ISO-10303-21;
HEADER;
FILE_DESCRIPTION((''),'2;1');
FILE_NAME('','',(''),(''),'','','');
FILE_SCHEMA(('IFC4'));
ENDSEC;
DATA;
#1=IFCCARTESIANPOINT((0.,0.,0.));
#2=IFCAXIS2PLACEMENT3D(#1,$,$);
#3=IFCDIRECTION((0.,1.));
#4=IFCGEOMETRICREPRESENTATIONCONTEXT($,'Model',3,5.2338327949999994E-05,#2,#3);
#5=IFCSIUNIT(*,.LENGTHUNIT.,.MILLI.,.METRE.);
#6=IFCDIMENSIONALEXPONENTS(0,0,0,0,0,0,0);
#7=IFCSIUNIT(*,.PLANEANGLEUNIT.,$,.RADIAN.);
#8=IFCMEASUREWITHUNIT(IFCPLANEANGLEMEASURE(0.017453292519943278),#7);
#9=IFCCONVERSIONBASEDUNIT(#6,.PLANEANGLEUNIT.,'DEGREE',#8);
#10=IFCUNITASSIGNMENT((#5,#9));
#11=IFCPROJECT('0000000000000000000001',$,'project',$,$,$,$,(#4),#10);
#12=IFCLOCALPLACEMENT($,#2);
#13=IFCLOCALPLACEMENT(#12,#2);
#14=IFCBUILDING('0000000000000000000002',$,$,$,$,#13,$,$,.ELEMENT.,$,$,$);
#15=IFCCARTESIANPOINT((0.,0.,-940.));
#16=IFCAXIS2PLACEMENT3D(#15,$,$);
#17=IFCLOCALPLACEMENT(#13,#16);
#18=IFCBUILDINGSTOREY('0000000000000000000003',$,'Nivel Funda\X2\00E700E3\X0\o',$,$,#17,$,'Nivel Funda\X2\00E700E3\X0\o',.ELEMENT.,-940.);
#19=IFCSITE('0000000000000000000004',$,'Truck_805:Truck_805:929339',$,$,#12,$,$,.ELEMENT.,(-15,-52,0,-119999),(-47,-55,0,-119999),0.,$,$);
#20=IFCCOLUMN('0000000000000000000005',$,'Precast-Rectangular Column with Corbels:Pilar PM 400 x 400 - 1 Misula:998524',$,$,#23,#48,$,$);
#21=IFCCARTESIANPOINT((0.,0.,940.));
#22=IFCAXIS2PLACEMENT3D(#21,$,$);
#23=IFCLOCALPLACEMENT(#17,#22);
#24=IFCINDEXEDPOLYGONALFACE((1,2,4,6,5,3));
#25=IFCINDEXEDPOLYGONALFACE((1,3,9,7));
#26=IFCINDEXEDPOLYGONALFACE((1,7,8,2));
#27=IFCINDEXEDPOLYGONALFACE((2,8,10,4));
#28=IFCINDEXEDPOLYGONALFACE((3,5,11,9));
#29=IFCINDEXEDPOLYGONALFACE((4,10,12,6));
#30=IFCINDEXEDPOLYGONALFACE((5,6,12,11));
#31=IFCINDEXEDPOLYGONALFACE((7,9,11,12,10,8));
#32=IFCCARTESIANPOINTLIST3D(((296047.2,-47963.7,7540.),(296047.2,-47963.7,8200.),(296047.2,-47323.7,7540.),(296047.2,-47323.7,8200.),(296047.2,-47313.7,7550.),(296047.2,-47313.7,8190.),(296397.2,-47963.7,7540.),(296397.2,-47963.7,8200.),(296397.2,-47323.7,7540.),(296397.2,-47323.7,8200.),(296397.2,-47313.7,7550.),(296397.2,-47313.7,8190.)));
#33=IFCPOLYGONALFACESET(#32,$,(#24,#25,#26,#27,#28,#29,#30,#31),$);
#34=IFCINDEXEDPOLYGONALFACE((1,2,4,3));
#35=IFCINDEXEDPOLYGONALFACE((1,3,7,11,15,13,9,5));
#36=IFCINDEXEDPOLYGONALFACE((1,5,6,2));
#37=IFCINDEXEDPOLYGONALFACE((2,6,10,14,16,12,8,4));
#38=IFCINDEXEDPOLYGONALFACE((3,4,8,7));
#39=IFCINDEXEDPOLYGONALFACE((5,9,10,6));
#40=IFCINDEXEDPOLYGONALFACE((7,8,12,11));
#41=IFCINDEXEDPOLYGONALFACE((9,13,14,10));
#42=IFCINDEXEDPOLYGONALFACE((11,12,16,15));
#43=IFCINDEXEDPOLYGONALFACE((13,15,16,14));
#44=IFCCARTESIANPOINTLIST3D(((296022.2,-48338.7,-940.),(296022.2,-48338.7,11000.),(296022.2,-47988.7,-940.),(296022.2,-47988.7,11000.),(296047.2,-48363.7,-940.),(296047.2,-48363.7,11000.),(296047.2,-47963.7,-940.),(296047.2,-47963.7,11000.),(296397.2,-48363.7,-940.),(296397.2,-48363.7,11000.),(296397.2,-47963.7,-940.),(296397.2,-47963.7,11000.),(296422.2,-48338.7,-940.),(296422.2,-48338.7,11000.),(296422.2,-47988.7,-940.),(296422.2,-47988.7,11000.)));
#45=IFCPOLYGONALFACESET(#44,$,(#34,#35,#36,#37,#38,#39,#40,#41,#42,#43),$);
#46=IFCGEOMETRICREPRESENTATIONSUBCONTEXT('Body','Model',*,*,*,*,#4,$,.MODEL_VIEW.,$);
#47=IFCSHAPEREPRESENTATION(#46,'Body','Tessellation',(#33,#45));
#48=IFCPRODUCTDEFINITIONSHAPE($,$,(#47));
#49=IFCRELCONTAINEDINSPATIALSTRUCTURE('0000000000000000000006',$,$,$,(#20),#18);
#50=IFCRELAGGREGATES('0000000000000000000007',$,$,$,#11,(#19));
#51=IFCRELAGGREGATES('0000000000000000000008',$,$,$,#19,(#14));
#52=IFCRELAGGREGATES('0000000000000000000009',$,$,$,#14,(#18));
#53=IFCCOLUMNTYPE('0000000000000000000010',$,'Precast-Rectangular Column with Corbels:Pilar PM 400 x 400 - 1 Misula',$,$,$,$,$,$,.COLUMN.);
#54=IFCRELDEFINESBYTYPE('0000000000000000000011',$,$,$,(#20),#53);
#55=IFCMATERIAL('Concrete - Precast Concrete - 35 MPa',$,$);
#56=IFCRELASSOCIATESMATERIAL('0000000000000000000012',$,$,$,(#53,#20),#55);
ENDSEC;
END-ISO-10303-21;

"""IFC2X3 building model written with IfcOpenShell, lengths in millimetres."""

from ifc_helpers import new_model, entity, si_unit, converted_unit, direction, frame, origin, place, context, subcontext, project, spatial, polyline, outline, extrude, source, transform, mapped, material, type_object, type_shapes, element, save


model = new_model("IFC2X3")

# Units and contexts
model_context = context("Model", 3, precision=5.2338327949999994e-05, world=origin(), true_north=direction((0.0, 1.0)))
body_context = subcontext(model_context, "Body", "Model", "MODEL_VIEW")
ifc_project = project(units=[si_unit("LENGTHUNIT", "METRE", prefix="MILLI"), converted_unit("PLANEANGLEUNIT", "DEGREE", entity("IfcPlaneAngleMeasure", 0.017453292519943278), si_unit("PLANEANGLEUNIT", "RADIAN"), dimensions=[0, 0, 0, 0, 0, 0, 0])], contexts=[model_context])

# Site, building, storey
site_placement = place(None, origin())
site = spatial("IfcSite", under=ifc_project, at=site_placement, Name="Truck_805:Truck_805:929339", CompositionType="ELEMENT", RefLatitude=(-15, -52, 0, -119999), RefLongitude=(-47, -55, 0, -119999), RefElevation=0.0)
building_placement = place(site_placement, origin())
building = spatial("IfcBuilding", under=site, at=building_placement, CompositionType="ELEMENT")
storey_placement = place(building_placement, frame((0.0, 0.0, -940.0)))
storey = spatial("IfcBuildingStorey", under=building, at=storey_placement, Name="Nivel Fundação", LongName="Nivel Fundação", CompositionType="ELEMENT", Elevation=-940.0)

# Column
ifc_material = material(Name="Concrete - Precast Concrete - 35 MPa")
column_type_1 = type_object("IfcColumnType", Name="Precast-Rectangular Column with Corbels:Pilar PM 400 x 400 - 1 Misula", PredefinedType="COLUMN", material=ifc_material)
shared_shape_1 = source(origin(), body_context, "Body", "SweptSolid", [
    extrude(outline(polyline([(-210.0, -330.0), (430.0, -330.0), (430.0, 330.0), (-210.0, 330.0), (-220.0, 320.0), (-220.0, -320.0), (-210.0, -330.0)])), frame((296047.2, -47533.7, 7870.0), z_axis=(1.0, 0.0, 0.0), x_axis=(0.0, -1.0, 0.0)), (0.0, 0.0, 1.0), 350.0),
    extrude(outline(polyline([(-175.0, -200.0), (175.0, -200.0), (200.0, -175.0), (200.0, 175.0), (175.0, 200.0), (-175.0, 200.0), (-200.0, 175.0), (-200.0, -175.0), (-175.0, -200.0)])), frame((296222.2, -48163.7, -940.0)), (0.0, 0.0, 1.0), 11940.0),
])
type_shapes(column_type_1, [shared_shape_1])
column_1_placement = place(storey_placement, frame((0.0, 0.0, 940.0)))
element("IfcColumn", 1, at=column_1_placement, inside=storey, type_object=column_type_1, material=ifc_material, Name="Precast-Rectangular Column with Corbels:Pilar PM 400 x 400 - 1 Misula:998524", context=body_context, shape_type="MappedRepresentation", body=[
    mapped(shared_shape_1, transform((0.0, 0.0, 0.0), scale=1.0)),
])

save(model, "model.ifc")
